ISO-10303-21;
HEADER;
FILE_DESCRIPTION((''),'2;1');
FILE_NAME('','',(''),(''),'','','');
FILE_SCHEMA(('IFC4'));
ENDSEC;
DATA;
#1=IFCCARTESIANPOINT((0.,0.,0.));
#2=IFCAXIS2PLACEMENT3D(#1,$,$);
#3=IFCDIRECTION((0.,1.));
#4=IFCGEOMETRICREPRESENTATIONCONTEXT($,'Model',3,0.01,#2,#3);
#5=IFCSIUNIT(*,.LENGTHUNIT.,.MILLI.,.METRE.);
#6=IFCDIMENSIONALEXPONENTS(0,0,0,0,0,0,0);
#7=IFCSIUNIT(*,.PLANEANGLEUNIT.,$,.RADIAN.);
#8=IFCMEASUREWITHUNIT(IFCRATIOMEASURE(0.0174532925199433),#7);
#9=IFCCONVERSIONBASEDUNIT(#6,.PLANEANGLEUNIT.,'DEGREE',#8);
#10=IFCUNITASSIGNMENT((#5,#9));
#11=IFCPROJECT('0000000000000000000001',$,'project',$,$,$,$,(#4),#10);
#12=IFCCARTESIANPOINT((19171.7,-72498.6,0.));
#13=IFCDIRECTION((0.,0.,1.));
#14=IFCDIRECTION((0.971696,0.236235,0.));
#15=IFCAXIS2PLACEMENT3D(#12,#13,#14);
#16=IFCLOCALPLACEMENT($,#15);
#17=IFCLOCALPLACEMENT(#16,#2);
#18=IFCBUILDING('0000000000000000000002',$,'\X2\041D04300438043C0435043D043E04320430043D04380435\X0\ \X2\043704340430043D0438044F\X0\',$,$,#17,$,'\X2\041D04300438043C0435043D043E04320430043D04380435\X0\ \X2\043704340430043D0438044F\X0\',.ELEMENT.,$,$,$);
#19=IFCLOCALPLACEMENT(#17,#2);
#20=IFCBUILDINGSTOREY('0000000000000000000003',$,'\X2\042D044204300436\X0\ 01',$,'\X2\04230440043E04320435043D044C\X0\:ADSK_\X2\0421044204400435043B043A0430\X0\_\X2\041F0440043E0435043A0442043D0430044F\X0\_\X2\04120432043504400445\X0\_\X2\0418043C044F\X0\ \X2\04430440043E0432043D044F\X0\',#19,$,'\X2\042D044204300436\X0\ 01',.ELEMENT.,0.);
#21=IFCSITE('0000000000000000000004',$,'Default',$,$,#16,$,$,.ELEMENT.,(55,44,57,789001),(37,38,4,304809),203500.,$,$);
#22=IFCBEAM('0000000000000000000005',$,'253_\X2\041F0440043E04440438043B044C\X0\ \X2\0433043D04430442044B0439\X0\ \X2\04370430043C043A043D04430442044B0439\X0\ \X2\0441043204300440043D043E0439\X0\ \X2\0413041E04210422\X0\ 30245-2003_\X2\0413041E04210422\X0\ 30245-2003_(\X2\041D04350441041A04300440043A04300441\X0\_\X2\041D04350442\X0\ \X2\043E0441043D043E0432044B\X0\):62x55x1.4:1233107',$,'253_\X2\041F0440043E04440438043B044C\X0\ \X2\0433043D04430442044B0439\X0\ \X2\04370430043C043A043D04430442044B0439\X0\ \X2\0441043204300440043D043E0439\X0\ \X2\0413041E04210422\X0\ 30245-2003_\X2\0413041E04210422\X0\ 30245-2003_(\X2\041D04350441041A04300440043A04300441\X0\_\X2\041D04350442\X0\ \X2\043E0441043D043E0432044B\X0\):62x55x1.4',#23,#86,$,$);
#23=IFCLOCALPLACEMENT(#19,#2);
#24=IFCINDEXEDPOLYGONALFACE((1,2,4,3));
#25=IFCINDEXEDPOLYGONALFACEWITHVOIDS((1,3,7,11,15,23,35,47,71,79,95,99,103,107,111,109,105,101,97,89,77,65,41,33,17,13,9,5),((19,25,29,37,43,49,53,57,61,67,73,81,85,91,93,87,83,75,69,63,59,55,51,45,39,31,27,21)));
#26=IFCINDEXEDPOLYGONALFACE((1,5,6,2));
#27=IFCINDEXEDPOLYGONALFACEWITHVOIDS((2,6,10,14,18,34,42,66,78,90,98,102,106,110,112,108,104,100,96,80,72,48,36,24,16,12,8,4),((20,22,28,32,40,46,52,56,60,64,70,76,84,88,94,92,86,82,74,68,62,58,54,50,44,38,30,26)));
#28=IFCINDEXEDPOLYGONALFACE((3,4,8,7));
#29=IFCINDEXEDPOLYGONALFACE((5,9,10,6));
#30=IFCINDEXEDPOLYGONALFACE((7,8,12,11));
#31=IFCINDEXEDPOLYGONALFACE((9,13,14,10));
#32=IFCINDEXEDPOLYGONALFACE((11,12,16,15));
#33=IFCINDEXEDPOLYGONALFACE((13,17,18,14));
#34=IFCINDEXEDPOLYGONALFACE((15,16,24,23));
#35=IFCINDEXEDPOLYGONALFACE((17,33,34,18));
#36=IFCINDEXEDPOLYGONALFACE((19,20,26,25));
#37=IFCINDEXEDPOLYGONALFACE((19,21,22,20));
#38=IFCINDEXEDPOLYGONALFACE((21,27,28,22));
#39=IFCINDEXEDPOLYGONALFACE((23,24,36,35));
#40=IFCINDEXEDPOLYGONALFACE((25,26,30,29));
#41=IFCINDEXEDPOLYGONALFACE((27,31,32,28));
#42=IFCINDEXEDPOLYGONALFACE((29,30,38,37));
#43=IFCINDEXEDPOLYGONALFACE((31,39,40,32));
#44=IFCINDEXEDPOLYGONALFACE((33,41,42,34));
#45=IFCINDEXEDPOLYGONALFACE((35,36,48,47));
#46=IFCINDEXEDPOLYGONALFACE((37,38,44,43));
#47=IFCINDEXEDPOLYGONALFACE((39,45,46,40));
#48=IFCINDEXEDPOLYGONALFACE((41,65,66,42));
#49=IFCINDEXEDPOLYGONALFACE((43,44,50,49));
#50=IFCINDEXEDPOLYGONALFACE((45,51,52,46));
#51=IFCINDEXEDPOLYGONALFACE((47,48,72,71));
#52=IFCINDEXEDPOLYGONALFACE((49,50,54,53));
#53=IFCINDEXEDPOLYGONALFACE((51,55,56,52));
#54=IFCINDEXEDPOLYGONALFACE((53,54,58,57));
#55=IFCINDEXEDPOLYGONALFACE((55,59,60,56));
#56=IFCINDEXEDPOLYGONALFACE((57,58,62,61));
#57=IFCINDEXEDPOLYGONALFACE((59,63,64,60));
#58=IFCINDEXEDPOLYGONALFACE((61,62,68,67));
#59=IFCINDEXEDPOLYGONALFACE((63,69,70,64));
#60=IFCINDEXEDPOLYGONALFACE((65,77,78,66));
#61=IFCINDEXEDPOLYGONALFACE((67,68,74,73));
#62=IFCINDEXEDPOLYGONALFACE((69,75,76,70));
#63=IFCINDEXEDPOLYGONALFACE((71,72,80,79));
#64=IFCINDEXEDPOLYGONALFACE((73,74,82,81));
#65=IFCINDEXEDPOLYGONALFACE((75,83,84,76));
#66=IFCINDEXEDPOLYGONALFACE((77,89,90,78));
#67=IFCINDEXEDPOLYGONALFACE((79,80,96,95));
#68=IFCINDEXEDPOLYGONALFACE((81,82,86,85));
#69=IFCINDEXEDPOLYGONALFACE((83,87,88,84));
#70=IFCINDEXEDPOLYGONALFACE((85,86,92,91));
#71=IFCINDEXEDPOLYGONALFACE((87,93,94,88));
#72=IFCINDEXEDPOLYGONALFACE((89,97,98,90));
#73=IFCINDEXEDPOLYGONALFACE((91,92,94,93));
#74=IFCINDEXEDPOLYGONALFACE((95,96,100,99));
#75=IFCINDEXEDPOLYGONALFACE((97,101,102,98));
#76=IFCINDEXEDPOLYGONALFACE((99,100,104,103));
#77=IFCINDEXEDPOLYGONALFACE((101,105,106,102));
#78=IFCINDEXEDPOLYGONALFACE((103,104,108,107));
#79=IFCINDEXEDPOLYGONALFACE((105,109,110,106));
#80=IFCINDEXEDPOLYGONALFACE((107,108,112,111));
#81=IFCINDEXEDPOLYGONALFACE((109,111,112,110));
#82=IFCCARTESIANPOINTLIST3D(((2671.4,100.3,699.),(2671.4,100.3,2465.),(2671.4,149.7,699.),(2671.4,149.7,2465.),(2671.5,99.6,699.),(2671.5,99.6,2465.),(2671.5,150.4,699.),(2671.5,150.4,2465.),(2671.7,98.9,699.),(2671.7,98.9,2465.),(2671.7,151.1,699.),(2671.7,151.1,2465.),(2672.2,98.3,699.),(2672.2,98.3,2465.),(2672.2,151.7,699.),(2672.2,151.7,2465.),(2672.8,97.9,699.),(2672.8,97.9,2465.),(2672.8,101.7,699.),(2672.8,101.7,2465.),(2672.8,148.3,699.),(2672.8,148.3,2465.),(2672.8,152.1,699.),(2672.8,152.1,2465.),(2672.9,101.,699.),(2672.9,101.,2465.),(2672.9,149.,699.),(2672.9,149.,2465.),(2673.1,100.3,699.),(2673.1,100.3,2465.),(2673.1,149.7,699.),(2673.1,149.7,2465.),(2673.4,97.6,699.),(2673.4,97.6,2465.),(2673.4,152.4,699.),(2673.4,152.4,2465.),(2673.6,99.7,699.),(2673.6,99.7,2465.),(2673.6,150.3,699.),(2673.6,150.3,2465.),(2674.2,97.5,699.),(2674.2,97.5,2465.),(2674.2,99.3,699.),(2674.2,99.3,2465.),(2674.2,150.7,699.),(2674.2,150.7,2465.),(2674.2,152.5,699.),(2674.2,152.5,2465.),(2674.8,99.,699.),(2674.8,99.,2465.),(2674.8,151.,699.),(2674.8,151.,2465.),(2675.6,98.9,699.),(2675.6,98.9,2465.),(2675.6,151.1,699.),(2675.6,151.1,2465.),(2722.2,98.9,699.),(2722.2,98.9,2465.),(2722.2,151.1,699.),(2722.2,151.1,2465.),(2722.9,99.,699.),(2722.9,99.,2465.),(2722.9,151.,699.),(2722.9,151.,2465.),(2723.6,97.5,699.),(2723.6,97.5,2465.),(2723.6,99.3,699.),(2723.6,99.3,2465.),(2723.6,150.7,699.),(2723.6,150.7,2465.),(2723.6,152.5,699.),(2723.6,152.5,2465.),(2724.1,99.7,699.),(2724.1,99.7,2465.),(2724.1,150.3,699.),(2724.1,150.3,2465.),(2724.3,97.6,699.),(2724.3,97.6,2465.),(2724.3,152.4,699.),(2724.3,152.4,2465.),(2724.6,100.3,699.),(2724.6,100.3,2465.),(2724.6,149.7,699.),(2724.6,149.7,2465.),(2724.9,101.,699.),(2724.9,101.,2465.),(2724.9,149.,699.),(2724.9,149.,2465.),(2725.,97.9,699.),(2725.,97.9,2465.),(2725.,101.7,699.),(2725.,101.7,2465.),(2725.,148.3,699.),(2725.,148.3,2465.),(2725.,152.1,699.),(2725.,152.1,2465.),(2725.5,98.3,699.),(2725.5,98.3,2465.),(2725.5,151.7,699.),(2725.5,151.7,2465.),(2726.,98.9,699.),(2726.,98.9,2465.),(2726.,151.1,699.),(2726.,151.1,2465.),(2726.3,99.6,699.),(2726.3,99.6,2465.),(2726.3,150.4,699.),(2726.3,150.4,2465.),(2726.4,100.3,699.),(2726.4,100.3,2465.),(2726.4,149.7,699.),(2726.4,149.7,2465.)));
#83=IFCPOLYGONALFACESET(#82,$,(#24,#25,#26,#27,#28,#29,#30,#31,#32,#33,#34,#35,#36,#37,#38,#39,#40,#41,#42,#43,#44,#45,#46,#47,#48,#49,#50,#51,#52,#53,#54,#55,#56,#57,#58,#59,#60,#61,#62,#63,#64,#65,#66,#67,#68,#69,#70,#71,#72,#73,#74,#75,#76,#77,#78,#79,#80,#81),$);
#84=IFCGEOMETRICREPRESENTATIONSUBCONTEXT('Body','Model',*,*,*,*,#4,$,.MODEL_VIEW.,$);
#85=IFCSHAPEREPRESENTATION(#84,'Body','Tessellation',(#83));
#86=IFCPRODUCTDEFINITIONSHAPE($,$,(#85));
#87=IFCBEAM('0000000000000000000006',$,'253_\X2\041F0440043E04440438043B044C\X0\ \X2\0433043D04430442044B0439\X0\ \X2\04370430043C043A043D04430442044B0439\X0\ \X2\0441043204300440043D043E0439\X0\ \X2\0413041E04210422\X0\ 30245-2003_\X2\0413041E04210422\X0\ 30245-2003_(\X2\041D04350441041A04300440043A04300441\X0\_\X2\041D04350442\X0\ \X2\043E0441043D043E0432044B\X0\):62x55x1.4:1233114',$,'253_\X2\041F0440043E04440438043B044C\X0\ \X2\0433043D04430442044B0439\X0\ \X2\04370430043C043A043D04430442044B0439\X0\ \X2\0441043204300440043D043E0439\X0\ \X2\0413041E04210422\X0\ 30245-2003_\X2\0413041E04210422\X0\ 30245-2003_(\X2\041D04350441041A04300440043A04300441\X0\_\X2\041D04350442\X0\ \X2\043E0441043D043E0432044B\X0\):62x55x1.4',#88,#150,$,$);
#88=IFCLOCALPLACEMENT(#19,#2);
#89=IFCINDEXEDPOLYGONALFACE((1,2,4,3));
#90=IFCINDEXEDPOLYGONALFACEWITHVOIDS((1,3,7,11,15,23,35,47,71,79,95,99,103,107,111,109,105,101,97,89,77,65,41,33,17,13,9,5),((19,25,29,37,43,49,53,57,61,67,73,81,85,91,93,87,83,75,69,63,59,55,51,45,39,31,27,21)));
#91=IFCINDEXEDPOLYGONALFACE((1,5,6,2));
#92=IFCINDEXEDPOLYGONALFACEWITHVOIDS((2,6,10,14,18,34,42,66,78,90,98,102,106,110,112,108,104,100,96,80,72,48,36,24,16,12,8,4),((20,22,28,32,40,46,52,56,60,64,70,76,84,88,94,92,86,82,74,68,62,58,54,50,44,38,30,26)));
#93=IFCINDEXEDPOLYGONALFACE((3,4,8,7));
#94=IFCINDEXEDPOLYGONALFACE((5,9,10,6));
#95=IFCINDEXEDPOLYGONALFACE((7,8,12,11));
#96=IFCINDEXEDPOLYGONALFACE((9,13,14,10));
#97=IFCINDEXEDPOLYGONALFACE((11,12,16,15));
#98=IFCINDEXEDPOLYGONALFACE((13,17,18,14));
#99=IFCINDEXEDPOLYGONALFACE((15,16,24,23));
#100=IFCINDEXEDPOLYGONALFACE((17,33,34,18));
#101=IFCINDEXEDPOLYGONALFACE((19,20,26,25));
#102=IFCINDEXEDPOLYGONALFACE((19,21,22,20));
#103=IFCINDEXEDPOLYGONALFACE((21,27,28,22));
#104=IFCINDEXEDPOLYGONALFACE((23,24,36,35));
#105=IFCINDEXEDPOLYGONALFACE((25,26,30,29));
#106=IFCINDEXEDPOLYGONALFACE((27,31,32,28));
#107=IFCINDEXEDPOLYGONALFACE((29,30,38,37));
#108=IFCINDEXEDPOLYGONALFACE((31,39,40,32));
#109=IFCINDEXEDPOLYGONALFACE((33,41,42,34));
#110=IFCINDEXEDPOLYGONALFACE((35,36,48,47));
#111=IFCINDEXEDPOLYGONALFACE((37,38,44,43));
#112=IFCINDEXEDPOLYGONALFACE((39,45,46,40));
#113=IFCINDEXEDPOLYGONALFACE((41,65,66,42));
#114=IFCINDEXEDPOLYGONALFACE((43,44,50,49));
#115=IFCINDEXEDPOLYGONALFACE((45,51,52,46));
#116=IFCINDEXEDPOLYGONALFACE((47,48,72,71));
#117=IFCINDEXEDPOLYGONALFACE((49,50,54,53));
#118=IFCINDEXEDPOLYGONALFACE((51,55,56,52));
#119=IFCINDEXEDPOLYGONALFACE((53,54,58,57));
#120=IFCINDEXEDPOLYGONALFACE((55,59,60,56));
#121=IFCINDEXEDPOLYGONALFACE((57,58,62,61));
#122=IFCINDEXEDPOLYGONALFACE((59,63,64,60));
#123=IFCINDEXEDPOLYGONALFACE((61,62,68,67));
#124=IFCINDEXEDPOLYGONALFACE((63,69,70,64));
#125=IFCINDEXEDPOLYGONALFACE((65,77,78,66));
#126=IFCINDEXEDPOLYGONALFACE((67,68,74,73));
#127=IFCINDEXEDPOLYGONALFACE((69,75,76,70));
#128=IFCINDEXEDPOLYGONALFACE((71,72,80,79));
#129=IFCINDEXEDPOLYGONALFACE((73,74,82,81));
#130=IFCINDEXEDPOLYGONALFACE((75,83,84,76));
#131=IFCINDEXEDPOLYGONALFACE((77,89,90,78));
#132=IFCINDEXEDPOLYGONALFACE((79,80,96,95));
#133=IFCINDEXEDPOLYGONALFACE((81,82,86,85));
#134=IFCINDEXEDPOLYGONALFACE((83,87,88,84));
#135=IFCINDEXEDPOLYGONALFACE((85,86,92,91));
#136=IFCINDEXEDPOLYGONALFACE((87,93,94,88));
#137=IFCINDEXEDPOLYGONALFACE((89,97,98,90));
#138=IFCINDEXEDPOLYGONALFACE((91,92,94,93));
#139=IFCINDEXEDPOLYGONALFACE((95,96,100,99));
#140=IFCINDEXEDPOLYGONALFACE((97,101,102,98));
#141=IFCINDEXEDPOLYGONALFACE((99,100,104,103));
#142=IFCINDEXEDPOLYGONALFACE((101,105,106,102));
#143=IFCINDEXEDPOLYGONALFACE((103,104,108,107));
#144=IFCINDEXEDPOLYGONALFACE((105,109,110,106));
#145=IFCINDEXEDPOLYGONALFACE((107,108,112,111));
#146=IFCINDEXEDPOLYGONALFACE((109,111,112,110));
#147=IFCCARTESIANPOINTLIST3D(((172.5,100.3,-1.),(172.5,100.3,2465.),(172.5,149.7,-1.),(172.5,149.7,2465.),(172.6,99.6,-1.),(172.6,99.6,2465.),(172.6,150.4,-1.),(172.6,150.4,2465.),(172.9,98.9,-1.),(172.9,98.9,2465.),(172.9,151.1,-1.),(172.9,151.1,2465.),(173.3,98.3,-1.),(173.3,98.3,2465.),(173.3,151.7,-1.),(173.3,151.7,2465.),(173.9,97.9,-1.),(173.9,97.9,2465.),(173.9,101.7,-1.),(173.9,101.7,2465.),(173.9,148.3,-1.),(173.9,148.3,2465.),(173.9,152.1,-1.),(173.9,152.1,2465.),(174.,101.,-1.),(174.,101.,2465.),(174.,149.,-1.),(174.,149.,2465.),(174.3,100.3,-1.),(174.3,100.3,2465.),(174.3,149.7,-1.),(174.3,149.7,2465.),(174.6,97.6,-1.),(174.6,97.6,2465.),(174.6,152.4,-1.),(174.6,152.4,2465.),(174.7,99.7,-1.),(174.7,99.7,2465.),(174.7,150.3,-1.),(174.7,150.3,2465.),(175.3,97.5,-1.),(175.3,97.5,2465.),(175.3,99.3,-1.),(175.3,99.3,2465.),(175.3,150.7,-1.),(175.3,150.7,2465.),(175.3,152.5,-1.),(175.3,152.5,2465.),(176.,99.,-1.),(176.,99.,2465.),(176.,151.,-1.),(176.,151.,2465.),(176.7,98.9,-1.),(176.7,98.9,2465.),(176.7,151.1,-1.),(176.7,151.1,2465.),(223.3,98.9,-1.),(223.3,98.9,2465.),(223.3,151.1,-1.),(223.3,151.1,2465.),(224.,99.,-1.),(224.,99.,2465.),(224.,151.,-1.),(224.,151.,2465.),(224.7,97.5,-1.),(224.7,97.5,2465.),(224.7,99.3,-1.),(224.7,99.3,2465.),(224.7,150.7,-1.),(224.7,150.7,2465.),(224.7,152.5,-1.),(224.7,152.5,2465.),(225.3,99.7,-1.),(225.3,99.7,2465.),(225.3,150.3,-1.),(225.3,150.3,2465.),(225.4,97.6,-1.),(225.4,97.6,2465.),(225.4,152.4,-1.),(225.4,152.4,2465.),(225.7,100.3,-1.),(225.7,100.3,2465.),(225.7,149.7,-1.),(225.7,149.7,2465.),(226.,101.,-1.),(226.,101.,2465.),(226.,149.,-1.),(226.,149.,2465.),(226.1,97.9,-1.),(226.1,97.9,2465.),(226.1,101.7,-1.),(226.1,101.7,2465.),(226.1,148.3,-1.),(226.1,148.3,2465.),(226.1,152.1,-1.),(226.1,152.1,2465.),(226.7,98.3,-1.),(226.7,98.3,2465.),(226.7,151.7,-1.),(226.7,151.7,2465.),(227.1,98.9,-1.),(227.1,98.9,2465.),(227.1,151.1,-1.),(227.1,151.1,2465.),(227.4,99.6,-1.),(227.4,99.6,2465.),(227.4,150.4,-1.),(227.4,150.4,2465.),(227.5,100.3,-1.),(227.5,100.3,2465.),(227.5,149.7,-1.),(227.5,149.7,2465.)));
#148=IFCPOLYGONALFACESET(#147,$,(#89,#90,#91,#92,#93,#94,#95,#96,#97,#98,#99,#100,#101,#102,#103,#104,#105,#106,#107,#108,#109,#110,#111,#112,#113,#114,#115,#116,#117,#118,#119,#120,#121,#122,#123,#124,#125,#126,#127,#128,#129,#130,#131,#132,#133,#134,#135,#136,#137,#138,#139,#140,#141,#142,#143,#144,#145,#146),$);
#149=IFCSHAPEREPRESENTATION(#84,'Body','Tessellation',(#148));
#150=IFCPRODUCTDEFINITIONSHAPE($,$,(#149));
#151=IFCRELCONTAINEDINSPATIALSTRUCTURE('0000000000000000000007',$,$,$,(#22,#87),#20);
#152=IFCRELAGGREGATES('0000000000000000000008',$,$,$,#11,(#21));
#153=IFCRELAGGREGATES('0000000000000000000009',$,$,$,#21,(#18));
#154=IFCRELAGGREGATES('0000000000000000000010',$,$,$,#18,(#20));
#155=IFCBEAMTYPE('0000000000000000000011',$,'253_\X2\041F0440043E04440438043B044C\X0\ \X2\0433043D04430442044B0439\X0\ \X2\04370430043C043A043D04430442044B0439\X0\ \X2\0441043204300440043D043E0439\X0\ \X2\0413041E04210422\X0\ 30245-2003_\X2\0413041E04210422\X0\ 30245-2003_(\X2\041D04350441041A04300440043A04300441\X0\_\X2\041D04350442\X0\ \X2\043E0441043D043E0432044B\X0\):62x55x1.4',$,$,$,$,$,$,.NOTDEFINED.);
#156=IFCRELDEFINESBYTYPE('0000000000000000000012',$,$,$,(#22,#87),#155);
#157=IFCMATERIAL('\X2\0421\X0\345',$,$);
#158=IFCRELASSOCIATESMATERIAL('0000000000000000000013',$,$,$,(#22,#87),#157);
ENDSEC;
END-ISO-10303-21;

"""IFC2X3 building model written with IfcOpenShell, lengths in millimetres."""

from ifc_helpers import new_model, entity, si_unit, converted_unit, direction, frame, frame_2d, origin, place, context, subcontext, project, spatial, polyline, circle_curve, parameter, trimmed, segment, composite_curve, outline, extrude, material, type_object, element, save


model = new_model("IFC2X3")

# Units and contexts
model_context = context("Model", 3, precision=0.01, world=origin(), true_north=direction((0.0, 1.0)))
body_context = subcontext(model_context, "Body", "Model", "MODEL_VIEW")
ifc_project = project(units=[si_unit("LENGTHUNIT", "METRE", prefix="MILLI"), converted_unit("PLANEANGLEUNIT", "DEGREE", entity("IfcRatioMeasure", 0.0174532925199433), si_unit("PLANEANGLEUNIT", "RADIAN"), dimensions=[0, 0, 0, 0, 0, 0, 0])], contexts=[model_context])

# Site, building, storey
site_placement = place(None, frame((19171.7, -72498.6, 0.0), z_axis=(0.0, 0.0, 1.0), x_axis=(0.971696, 0.236235, 0.0)))
site = spatial("IfcSite", under=ifc_project, at=site_placement, Name="Default", CompositionType="ELEMENT", RefLatitude=(55, 44, 57, 789001), RefLongitude=(37, 38, 4, 304809), RefElevation=203500.0)
building_placement = place(site_placement, origin())
building = spatial("IfcBuilding", under=site, at=building_placement, Name="Наименование здания", LongName="Наименование здания", CompositionType="ELEMENT")
storey_placement = place(building_placement, origin())
storey = spatial("IfcBuildingStorey", under=building, at=storey_placement, Name="Этаж 01", ObjectType="Уровень:ADSK_Стрелка_Проектная_Вверх_Имя уровня", LongName="Этаж 01", CompositionType="ELEMENT", Elevation=0.0)

# Beams
ifc_material_1 = material(Name="С345")
beam_type_1 = type_object("IfcBeamType", Name="253_Профиль гнутый замкнутый сварной ГОСТ 30245-2003_ГОСТ 30245-2003_(НесКаркас_Нет основы):62x55x1.4", PredefinedType="NOTDEFINED")
beam_1_placement = place(storey_placement, frame((2669.8, 95.9, 699.0), z_axis=(1.0, 0.0, 0.0), x_axis=(0.0, 0.0, 1.0)))
element("IfcBeam", 1, at=beam_1_placement, inside=storey, type_object=beam_type_1, material=ifc_material_1, Name="253_Профиль гнутый замкнутый сварной ГОСТ 30245-2003_ГОСТ 30245-2003_(НесКаркас_Нет основы):62x55x1.4:1233107", ObjectType="253_Профиль гнутый замкнутый сварной ГОСТ 30245-2003_ГОСТ 30245-2003_(НесКаркас_Нет основы):62x55x1.4", context=body_context, shape_type="SweptSolid", body=[
    extrude(outline(composite_curve([segment(trimmed(circle_curve(frame_2d((24.7, -24.7), x_axis=(1.0, 0.0)), 2.8), [parameter(270.0)], [parameter(0.0)], True, "PARAMETER"), True, "CONTINUOUS"), segment(polyline([(27.5, -24.7), (27.5, 24.7)]), True, "CONTINUOUS"), segment(trimmed(circle_curve(frame_2d((24.7, 24.7), x_axis=(1.0, 0.0)), 2.8), [parameter(0.0)], [parameter(90.0)], True, "PARAMETER"), True, "CONTINUOUS"), segment(polyline([(24.7, 27.5), (-24.7, 27.5)]), True, "CONTINUOUS"), segment(trimmed(circle_curve(frame_2d((-24.7, 24.7), x_axis=(1.0, 0.0)), 2.8), [parameter(90.0)], [parameter(180.0)], True, "PARAMETER"), True, "CONTINUOUS"), segment(polyline([(-27.5, 24.7), (-27.5, -24.7)]), True, "CONTINUOUS"), segment(trimmed(circle_curve(frame_2d((-24.7, -24.7), x_axis=(1.0, 0.0)), 2.8), [parameter(180.0)], [parameter(270.0)], True, "PARAMETER"), True, "CONTINUOUS"), segment(polyline([(-24.7, -27.5), (24.7, -27.5)]), True, "CONTINUOUS")], self_intersect=False), holes=[composite_curve([segment(polyline([(23.3, -26.1), (-23.3, -26.1)]), True, "CONTINUOUS"), segment(trimmed(circle_curve(frame_2d((-23.3, -23.3), x_axis=(1.0, 0.0)), 2.8), [parameter(180.0)], [parameter(270.0)], True, "PARAMETER"), False, "CONTINUOUS"), segment(polyline([(-26.1, -23.3), (-26.1, 23.3)]), True, "CONTINUOUS"), segment(trimmed(circle_curve(frame_2d((-23.3, 23.3), x_axis=(1.0, 0.0)), 2.8), [parameter(90.0)], [parameter(180.0)], True, "PARAMETER"), False, "CONTINUOUS"), segment(polyline([(-23.3, 26.1), (23.3, 26.1)]), True, "CONTINUOUS"), segment(trimmed(circle_curve(frame_2d((23.3, 23.3), x_axis=(1.0, 0.0)), 2.8), [parameter(0.0)], [parameter(90.0)], True, "PARAMETER"), False, "CONTINUOUS"), segment(polyline([(26.1, 23.3), (26.1, -23.3)]), True, "CONTINUOUS"), segment(trimmed(circle_curve(frame_2d((23.3, -23.3), x_axis=(1.0, 0.0)), 2.8), [parameter(270.0)], [parameter(0.0)], True, "PARAMETER"), False, "CONTINUOUS")], self_intersect=False)]), frame((0.0, -29.1, 29.1), z_axis=(1.0, 0.0, 0.0), x_axis=(0.0, -1.0, 0.0)), (0.0, 0.0, 1.0), 1766.0),
])
beam_2_placement = place(storey_placement, frame((170.9, 95.9, -1.0), z_axis=(1.0, 0.0, 0.0), x_axis=(0.0, 0.0, 1.0)))
element("IfcBeam", 2, at=beam_2_placement, inside=storey, type_object=beam_type_1, material=ifc_material_1, Name="253_Профиль гнутый замкнутый сварной ГОСТ 30245-2003_ГОСТ 30245-2003_(НесКаркас_Нет основы):62x55x1.4:1233114", ObjectType="253_Профиль гнутый замкнутый сварной ГОСТ 30245-2003_ГОСТ 30245-2003_(НесКаркас_Нет основы):62x55x1.4", context=body_context, shape_type="SweptSolid", body=[
    extrude(outline(composite_curve([segment(trimmed(circle_curve(frame_2d((24.7, -24.7), x_axis=(1.0, 0.0)), 2.8), [parameter(270.0)], [parameter(0.0)], True, "PARAMETER"), True, "CONTINUOUS"), segment(polyline([(27.5, -24.7), (27.5, 24.7)]), True, "CONTINUOUS"), segment(trimmed(circle_curve(frame_2d((24.7, 24.7), x_axis=(1.0, 0.0)), 2.8), [parameter(0.0)], [parameter(90.0)], True, "PARAMETER"), True, "CONTINUOUS"), segment(polyline([(24.7, 27.5), (-24.7, 27.5)]), True, "CONTINUOUS"), segment(trimmed(circle_curve(frame_2d((-24.7, 24.7), x_axis=(1.0, 0.0)), 2.8), [parameter(90.0)], [parameter(180.0)], True, "PARAMETER"), True, "CONTINUOUS"), segment(polyline([(-27.5, 24.7), (-27.5, -24.7)]), True, "CONTINUOUS"), segment(trimmed(circle_curve(frame_2d((-24.7, -24.7), x_axis=(1.0, 0.0)), 2.8), [parameter(180.0)], [parameter(270.0)], True, "PARAMETER"), True, "CONTINUOUS"), segment(polyline([(-24.7, -27.5), (24.7, -27.5)]), True, "CONTINUOUS")], self_intersect=False), holes=[composite_curve([segment(polyline([(23.3, -26.1), (-23.3, -26.1)]), True, "CONTINUOUS"), segment(trimmed(circle_curve(frame_2d((-23.3, -23.3), x_axis=(1.0, 0.0)), 2.8), [parameter(180.0)], [parameter(270.0)], True, "PARAMETER"), False, "CONTINUOUS"), segment(polyline([(-26.1, -23.3), (-26.1, 23.3)]), True, "CONTINUOUS"), segment(trimmed(circle_curve(frame_2d((-23.3, 23.3), x_axis=(1.0, 0.0)), 2.8), [parameter(90.0)], [parameter(180.0)], True, "PARAMETER"), False, "CONTINUOUS"), segment(polyline([(-23.3, 26.1), (23.3, 26.1)]), True, "CONTINUOUS"), segment(trimmed(circle_curve(frame_2d((23.3, 23.3), x_axis=(1.0, 0.0)), 2.8), [parameter(0.0)], [parameter(90.0)], True, "PARAMETER"), False, "CONTINUOUS"), segment(polyline([(26.1, 23.3), (26.1, -23.3)]), True, "CONTINUOUS"), segment(trimmed(circle_curve(frame_2d((23.3, -23.3), x_axis=(1.0, 0.0)), 2.8), [parameter(270.0)], [parameter(0.0)], True, "PARAMETER"), False, "CONTINUOUS")], self_intersect=False)]), frame((0.0, -29.1, 29.1), z_axis=(1.0, 0.0, 0.0), x_axis=(0.0, -1.0, 0.0)), (0.0, 0.0, 1.0), 2466.0),
])

save(model, "model.ifc")
